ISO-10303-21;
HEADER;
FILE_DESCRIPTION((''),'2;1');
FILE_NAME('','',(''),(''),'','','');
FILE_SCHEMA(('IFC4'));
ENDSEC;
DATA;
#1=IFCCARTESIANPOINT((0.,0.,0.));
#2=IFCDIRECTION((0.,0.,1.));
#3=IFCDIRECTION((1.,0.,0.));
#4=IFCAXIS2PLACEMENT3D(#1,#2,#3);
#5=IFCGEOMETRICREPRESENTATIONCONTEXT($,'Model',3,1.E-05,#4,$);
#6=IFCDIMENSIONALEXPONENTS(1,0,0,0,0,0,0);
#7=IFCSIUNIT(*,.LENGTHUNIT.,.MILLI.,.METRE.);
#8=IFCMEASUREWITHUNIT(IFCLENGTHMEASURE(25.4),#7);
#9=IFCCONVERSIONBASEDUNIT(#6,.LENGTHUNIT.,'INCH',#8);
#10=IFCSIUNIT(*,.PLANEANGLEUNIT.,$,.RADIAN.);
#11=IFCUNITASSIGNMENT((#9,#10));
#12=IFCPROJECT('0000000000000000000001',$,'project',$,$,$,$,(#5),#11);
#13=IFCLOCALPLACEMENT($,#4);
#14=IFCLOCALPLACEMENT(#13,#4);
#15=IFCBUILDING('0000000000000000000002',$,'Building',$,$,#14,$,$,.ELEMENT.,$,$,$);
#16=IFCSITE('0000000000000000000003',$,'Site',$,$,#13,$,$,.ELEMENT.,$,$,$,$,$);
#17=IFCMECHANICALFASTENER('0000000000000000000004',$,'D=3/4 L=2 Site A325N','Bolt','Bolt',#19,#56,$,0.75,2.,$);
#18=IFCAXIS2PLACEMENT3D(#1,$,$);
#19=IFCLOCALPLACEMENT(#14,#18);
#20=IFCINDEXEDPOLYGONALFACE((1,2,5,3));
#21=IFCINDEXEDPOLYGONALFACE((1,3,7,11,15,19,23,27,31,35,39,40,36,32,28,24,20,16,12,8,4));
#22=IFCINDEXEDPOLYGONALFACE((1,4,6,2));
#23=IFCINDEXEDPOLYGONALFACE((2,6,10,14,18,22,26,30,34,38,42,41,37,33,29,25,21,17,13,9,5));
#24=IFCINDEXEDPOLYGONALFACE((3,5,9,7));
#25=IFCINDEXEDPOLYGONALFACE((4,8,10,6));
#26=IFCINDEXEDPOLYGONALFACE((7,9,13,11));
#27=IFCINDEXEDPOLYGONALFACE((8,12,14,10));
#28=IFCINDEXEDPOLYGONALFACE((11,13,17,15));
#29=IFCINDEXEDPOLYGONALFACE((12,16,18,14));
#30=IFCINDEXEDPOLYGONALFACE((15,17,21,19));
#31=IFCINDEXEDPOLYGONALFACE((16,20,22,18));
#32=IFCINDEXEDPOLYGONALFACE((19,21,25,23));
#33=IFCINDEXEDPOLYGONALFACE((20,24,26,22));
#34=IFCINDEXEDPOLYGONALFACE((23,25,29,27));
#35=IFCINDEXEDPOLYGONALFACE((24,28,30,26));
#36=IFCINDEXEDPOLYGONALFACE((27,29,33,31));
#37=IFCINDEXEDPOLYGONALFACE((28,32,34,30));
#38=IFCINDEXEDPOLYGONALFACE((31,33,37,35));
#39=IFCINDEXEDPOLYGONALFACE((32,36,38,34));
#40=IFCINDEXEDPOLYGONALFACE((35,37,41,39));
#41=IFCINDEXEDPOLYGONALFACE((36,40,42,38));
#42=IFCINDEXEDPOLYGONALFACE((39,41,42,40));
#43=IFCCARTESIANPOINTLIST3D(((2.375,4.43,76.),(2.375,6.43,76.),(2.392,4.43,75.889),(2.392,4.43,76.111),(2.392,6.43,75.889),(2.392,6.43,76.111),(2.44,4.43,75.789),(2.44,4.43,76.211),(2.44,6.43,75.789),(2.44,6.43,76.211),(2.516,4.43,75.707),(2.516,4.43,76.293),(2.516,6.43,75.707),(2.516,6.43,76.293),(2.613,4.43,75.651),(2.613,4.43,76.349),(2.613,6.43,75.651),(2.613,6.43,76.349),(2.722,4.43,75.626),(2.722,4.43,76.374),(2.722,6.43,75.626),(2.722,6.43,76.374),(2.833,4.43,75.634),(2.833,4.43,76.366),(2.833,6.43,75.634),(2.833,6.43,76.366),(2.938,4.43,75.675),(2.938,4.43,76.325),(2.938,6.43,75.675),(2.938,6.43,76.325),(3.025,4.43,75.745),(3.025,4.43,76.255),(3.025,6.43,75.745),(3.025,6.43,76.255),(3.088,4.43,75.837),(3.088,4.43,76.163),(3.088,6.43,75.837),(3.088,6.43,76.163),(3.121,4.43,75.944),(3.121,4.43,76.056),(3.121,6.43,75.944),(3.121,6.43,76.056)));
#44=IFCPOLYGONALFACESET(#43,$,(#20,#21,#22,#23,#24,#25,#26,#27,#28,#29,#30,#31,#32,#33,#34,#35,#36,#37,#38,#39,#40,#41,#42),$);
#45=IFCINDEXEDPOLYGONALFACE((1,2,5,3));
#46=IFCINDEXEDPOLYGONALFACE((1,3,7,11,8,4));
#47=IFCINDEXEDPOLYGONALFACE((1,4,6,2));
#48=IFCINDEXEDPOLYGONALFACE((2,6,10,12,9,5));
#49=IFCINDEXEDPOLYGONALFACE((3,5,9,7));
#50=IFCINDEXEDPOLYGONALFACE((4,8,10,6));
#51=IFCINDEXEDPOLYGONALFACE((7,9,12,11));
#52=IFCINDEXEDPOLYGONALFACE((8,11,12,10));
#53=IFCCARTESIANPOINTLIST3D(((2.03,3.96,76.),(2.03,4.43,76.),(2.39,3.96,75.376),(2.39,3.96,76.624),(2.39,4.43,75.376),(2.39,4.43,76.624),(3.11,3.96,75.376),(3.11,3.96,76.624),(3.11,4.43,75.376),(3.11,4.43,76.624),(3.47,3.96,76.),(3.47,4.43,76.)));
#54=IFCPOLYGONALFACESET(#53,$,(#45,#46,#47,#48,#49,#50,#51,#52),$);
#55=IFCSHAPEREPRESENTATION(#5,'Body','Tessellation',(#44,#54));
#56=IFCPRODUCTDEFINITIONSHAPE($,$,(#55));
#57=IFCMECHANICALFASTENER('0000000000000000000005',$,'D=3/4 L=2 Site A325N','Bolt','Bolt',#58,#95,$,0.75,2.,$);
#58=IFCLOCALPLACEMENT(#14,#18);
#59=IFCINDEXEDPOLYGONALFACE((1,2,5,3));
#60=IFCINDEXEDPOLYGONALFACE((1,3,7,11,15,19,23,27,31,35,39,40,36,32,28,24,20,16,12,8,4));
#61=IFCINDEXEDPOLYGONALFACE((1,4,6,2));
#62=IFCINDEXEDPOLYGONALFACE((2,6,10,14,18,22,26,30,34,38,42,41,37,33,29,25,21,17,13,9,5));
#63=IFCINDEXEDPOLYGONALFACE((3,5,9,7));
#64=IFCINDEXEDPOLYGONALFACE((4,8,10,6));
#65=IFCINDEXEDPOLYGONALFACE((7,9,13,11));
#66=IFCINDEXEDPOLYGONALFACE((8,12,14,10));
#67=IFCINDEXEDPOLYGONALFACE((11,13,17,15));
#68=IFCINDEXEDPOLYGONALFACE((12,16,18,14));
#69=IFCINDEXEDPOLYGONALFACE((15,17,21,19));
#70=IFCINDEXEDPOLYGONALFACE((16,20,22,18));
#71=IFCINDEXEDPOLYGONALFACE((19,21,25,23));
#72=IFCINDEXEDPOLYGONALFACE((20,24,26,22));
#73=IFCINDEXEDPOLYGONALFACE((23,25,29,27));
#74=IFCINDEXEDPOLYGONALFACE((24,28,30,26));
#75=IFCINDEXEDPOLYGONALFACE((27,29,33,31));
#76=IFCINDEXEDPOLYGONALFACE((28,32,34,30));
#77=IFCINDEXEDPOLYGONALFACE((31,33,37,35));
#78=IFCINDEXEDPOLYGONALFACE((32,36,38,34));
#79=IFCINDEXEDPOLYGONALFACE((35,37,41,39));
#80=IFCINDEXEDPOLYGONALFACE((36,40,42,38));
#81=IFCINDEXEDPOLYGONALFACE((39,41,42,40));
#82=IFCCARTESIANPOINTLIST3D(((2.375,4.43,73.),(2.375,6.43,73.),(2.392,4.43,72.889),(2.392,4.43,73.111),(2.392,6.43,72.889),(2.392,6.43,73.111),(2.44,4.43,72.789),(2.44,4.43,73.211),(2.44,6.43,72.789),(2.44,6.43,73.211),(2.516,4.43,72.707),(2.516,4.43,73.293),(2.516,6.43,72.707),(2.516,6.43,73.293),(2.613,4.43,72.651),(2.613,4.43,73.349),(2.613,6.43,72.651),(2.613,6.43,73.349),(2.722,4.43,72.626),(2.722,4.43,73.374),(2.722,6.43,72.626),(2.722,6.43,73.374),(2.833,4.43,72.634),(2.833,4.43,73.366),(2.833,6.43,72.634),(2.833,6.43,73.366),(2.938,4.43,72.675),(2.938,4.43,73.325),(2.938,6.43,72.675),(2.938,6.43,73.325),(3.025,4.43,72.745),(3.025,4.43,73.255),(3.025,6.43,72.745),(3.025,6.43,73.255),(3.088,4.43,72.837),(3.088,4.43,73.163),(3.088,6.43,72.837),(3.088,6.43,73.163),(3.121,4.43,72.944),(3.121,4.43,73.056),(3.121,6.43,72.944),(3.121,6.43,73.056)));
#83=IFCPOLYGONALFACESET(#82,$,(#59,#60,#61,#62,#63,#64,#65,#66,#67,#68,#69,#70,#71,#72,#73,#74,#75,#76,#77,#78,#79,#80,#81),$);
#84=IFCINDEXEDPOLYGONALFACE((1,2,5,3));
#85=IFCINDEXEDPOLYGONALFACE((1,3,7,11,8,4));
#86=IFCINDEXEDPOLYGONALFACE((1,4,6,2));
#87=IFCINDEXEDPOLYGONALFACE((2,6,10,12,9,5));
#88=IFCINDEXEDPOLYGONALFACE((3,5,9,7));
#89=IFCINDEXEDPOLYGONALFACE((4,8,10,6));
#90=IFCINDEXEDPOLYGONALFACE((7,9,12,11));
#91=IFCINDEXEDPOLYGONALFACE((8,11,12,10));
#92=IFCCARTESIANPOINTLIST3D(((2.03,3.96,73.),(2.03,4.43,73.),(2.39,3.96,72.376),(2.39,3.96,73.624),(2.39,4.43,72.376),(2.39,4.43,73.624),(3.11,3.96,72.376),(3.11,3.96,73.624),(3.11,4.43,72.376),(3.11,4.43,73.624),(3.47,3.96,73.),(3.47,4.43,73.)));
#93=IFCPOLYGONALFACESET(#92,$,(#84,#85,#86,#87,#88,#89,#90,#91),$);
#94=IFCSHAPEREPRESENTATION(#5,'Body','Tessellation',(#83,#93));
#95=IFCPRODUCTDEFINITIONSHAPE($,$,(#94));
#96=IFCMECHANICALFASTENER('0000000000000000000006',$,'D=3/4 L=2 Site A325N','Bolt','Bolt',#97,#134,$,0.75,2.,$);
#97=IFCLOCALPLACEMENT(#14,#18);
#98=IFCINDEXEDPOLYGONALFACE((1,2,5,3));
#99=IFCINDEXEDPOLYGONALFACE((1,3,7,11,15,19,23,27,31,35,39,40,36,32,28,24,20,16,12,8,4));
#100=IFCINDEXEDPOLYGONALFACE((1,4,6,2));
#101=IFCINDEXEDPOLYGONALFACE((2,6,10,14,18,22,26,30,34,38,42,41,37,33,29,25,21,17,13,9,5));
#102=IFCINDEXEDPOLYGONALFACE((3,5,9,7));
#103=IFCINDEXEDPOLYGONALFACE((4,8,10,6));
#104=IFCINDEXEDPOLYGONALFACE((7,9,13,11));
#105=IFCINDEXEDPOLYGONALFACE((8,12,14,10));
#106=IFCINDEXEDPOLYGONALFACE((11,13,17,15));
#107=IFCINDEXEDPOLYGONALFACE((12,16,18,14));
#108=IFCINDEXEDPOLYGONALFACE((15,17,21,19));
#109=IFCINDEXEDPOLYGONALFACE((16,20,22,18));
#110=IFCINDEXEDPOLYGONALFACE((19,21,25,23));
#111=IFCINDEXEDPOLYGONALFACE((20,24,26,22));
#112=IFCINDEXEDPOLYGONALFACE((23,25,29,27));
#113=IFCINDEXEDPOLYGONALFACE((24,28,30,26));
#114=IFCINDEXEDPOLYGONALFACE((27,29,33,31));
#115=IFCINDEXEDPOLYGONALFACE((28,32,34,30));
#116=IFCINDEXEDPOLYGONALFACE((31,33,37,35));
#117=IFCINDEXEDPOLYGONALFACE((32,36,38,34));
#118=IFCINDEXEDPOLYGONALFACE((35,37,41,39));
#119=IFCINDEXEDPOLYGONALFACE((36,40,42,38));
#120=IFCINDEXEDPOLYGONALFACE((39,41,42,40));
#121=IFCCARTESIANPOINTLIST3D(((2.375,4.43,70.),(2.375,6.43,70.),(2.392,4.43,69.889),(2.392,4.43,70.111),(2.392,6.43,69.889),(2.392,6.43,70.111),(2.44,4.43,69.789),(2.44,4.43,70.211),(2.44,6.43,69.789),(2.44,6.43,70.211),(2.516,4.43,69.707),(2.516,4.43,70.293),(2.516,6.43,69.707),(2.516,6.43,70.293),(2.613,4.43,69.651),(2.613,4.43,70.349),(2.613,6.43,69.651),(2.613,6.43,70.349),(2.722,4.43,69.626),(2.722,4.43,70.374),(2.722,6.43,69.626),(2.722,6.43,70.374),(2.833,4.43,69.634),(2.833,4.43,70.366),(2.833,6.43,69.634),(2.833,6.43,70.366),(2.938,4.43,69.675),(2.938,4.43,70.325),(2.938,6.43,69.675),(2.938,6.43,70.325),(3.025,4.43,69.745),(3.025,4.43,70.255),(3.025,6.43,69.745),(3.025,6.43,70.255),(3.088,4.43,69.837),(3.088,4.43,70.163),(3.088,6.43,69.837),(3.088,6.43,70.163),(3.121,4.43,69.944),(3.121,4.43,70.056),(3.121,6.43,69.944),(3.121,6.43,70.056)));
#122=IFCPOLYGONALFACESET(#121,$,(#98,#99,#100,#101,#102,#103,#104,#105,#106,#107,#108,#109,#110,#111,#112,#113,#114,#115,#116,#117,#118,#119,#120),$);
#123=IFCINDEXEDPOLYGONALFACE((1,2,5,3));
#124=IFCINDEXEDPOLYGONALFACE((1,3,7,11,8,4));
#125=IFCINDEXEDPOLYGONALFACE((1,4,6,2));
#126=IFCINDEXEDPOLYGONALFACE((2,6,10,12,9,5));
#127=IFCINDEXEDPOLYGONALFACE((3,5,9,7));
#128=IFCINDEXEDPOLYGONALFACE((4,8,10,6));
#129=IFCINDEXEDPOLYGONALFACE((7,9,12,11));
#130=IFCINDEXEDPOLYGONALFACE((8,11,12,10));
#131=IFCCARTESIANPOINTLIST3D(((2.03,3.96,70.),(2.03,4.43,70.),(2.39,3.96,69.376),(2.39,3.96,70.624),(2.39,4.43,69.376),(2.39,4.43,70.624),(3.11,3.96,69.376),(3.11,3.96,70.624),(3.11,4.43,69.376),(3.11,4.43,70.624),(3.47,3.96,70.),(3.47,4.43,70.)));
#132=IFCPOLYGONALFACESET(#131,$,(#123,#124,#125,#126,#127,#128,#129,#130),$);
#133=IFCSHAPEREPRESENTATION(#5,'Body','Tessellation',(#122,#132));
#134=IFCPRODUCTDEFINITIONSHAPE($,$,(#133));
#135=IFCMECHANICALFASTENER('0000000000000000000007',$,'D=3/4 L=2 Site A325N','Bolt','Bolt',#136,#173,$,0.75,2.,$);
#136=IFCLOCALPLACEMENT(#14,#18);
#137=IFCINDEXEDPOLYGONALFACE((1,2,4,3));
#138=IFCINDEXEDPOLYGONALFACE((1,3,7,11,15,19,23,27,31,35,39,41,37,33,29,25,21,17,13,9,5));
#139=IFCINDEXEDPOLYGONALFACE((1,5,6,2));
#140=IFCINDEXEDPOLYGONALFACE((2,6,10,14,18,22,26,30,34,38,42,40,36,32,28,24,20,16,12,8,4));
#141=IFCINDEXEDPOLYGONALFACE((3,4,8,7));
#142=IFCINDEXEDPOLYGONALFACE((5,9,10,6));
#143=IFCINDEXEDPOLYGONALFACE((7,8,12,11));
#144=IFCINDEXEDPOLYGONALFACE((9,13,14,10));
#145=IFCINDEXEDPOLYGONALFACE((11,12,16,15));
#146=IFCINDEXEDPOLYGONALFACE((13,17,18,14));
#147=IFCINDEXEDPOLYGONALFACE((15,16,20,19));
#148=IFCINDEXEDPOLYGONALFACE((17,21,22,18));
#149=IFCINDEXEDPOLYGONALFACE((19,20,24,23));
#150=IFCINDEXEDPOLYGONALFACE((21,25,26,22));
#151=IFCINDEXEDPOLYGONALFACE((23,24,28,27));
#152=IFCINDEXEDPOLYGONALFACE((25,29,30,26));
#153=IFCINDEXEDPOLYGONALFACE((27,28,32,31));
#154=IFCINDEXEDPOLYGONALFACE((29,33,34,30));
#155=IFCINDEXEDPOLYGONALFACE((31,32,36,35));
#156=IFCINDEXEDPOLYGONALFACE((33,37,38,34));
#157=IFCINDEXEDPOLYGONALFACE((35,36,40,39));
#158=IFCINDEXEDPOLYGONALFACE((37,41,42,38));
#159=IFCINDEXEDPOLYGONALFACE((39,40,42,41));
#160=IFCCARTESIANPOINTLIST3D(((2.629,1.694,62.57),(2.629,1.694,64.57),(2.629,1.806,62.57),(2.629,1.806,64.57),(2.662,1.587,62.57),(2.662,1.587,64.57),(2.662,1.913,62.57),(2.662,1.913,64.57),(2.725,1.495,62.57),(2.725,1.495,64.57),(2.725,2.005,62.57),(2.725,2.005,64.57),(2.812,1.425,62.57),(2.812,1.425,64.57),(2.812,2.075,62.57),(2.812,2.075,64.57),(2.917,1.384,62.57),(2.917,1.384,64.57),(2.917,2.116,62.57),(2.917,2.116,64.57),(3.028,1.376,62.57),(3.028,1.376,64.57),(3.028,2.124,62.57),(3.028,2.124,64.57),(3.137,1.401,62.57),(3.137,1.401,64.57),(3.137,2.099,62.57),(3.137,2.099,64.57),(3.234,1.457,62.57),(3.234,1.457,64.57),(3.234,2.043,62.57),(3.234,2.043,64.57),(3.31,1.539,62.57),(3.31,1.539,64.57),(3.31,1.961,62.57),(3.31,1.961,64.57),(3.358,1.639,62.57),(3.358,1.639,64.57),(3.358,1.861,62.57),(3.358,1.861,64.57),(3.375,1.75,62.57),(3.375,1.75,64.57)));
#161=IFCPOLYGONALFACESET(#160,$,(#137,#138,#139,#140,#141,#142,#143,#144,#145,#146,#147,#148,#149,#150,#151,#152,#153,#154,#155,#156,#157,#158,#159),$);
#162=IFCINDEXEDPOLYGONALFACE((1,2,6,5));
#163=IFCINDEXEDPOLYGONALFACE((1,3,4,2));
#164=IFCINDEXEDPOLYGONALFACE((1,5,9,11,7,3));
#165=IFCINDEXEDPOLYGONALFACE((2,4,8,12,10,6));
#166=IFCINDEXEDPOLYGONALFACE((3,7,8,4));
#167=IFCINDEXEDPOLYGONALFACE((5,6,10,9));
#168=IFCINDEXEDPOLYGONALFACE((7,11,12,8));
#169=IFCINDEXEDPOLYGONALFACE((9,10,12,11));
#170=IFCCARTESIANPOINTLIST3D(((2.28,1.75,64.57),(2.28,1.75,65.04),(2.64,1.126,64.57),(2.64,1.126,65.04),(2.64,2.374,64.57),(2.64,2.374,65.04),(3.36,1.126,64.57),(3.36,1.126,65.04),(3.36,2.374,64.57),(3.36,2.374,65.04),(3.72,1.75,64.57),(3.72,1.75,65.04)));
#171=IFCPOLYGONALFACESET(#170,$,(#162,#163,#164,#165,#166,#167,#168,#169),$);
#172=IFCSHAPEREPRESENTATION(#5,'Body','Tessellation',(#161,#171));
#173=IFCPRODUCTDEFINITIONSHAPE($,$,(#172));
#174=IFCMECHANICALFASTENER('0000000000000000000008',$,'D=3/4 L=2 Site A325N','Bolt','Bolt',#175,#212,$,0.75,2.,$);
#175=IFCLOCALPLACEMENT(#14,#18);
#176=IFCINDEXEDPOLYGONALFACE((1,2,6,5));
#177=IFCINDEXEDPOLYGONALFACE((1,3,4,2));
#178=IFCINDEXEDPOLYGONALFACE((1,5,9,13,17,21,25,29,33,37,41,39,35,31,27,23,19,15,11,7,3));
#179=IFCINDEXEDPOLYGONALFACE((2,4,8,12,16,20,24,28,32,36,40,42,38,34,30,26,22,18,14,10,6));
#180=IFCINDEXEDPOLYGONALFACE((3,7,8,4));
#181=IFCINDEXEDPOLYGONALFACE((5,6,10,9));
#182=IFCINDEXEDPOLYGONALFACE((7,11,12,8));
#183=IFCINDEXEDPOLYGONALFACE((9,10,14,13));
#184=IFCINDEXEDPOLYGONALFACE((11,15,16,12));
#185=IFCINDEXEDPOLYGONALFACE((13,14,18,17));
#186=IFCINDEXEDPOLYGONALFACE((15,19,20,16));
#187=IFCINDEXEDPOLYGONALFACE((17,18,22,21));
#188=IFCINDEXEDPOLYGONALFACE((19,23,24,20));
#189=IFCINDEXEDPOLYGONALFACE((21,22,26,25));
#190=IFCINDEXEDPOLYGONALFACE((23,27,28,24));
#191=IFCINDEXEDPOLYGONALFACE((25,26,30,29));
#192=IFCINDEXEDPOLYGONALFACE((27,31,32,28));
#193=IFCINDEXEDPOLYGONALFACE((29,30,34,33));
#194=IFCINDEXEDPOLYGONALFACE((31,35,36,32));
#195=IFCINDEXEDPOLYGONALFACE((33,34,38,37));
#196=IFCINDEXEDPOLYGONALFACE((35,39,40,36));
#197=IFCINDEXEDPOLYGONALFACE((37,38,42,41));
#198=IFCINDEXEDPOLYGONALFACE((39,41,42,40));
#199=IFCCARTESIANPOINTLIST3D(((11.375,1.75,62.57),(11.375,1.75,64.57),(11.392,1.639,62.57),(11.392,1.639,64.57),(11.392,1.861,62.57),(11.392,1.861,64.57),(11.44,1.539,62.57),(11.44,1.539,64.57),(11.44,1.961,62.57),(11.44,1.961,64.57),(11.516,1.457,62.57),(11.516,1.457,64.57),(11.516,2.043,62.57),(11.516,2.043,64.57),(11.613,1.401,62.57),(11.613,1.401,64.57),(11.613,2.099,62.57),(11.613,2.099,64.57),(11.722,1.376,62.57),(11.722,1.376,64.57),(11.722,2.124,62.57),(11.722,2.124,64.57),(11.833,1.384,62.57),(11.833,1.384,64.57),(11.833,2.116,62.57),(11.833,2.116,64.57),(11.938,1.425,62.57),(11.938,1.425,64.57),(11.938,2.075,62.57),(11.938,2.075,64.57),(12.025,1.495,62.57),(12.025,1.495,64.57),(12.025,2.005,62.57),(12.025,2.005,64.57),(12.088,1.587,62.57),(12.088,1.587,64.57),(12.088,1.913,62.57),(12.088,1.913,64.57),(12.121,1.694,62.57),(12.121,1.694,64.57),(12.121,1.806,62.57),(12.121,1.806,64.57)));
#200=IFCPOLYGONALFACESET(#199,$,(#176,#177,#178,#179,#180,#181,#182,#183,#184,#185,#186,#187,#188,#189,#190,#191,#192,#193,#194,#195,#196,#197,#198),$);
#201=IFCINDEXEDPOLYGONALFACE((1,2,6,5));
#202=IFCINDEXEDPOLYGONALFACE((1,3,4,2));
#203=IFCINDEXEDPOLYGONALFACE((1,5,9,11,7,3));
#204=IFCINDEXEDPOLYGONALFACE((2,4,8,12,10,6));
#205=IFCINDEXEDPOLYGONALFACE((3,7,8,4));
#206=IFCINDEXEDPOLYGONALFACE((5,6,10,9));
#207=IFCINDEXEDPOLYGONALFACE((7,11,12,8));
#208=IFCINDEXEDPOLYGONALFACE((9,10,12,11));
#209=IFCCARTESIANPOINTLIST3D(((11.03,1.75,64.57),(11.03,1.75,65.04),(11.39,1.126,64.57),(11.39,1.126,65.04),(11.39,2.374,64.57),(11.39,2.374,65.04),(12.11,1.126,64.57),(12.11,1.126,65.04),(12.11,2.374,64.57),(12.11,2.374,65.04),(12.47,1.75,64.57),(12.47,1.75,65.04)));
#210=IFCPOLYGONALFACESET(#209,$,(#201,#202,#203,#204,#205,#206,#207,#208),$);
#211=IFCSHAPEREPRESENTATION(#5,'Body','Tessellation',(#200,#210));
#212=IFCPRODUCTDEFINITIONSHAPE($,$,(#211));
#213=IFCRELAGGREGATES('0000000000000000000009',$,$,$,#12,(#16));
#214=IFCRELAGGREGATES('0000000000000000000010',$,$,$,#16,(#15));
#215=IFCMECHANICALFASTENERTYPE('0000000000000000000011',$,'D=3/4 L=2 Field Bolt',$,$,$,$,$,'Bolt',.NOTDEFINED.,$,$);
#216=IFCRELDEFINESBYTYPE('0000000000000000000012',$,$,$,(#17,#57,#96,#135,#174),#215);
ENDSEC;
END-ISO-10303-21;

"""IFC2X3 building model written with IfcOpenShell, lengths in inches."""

from ifc_helpers import new_model, entity, si_unit, converted_unit, frame, origin_with_axes, origin_2d_with_axis, place, context, project, spatial, polyline, circle, outline, extrude, source, transform, mapped, type_object, type_shapes, element, save


model = new_model("IFC2X3")

# Units and contexts
model_context = context("Model", 3, precision=1e-05, world=origin_with_axes())
ifc_project = project(units=[converted_unit("LENGTHUNIT", "INCH", entity("IfcLengthMeasure", 25.4), si_unit("LENGTHUNIT", "METRE", prefix="MILLI"), dimensions=[1, 0, 0, 0, 0, 0, 0]), si_unit("PLANEANGLEUNIT", "RADIAN")], contexts=[model_context])

# Site, building
site_placement = place(None, origin_with_axes())
site = spatial("IfcSite", under=ifc_project, at=site_placement, Name="Site", CompositionType="ELEMENT")
building_placement = place(site_placement, origin_with_axes())
building = spatial("IfcBuilding", under=site, at=building_placement, Name="Building", CompositionType="ELEMENT")

# Mechanical fasteners
mechanical_fastener_type_1 = type_object("IfcMechanicalFastenerType", Name="D=3/4 L=2 Field Bolt", ElementType="Bolt")
shared_shape_1 = source(origin_with_axes(), model_context, "Body", "SweptSolid", [
    extrude(circle(Radius=0.375, at=origin_2d_with_axis()), frame((0.0, 0.0, 0.0), z_axis=(1.0, 0.0, 0.0), x_axis=(0.0, 1.0, 0.0)), (0.0, 0.0, 1.0), 2.0),
    extrude(outline(polyline([(-0.72, 0.0), (-0.36, 0.624), (0.36, 0.624), (0.72, 0.0), (0.36, -0.624), (-0.36, -0.624), (-0.72, 0.0)])), frame((0.0, 0.0, 0.0), z_axis=(1.0, 0.0, 0.0), x_axis=(0.0, 1.0, 0.0)), (0.0, 0.0, -1.0), 0.47),
])
type_shapes(mechanical_fastener_type_1, [shared_shape_1])
placement_1 = place(building_placement, frame((0.0, 0.0, 80.0), z_axis=(0.0, 0.0, 1.0), x_axis=(0.0, 1.0, 0.0)))
placement_2 = place(placement_1, frame((4.43, -2.75, -10.0), z_axis=(0.0, 0.0, 1.0), x_axis=(1.0, 0.0, 0.0)))
for number, where, z_axis, x_axis, name in (
    (1, (0.0, 0.0, 6.0), (0.0, 0.0, 1.0), (1.0, 0.0, 0.0), "D=3/4 L=2 Site A325N"),
    (2, (0.0, 0.0, 3.0), (0.0, 0.0, 1.0), (1.0, 0.0, 0.0), "D=3/4 L=2 Site A325N"),
    (3, (0.0, 0.0, 0.0), (0.0, 0.0, 1.0), (1.0, 0.0, 0.0), "D=3/4 L=2 Site A325N"),
):
    element("IfcMechanicalFastener", number, at=place(placement_2, frame(where, z_axis=z_axis, x_axis=x_axis)), type_object=mechanical_fastener_type_1, Name=name, Description="Bolt", ObjectType="Bolt", NominalDiameter=0.75, NominalLength=2.0, context=model_context, shape_type="MappedRepresentation", body=[
        mapped(shared_shape_1, transform((0.0, 0.0, 0.0), scale=1.0)),
    ])
placement_3 = place(building_placement, frame((0.0, 0.0, 80.0), z_axis=(0.0, 0.0, 1.0), x_axis=(1.0, 0.0, 0.0)))
placement_4 = place(placement_3, frame((3.0, 1.75, -15.43), z_axis=(0.0, -1.0, 0.0), x_axis=(0.0, 0.0, -1.0)))
mechanical_fastener_1_placement = place(placement_4, origin_with_axes())
element("IfcMechanicalFastener", 4, at=mechanical_fastener_1_placement, type_object=mechanical_fastener_type_1, Name="D=3/4 L=2 Site A325N", Description="Bolt", ObjectType="Bolt", NominalDiameter=0.75, NominalLength=2.0, context=model_context, shape_type="MappedRepresentation", body=[
    mapped(shared_shape_1, transform((0.0, 0.0, 0.0), scale=1.0)),
])
placement_5 = place(building_placement, frame((14.0, 0.0, 49.0), z_axis=(0.0, -1.0, 0.0), x_axis=(0.0, 0.0, 1.0)))
placement_6 = place(placement_5, frame((15.57, 2.25, -1.75), z_axis=(0.0, 0.0, -1.0), x_axis=(-1.0, 0.0, 0.0)))
mechanical_fastener_2_placement = place(placement_6, origin_with_axes())
element("IfcMechanicalFastener", 5, at=mechanical_fastener_2_placement, type_object=mechanical_fastener_type_1, Name="D=3/4 L=2 Site A325N", Description="Bolt", ObjectType="Bolt", NominalDiameter=0.75, NominalLength=2.0, context=model_context, shape_type="MappedRepresentation", body=[
    mapped(shared_shape_1, transform((0.0, 0.0, 0.0), scale=1.0)),
])

save(model, "model.ifc")
